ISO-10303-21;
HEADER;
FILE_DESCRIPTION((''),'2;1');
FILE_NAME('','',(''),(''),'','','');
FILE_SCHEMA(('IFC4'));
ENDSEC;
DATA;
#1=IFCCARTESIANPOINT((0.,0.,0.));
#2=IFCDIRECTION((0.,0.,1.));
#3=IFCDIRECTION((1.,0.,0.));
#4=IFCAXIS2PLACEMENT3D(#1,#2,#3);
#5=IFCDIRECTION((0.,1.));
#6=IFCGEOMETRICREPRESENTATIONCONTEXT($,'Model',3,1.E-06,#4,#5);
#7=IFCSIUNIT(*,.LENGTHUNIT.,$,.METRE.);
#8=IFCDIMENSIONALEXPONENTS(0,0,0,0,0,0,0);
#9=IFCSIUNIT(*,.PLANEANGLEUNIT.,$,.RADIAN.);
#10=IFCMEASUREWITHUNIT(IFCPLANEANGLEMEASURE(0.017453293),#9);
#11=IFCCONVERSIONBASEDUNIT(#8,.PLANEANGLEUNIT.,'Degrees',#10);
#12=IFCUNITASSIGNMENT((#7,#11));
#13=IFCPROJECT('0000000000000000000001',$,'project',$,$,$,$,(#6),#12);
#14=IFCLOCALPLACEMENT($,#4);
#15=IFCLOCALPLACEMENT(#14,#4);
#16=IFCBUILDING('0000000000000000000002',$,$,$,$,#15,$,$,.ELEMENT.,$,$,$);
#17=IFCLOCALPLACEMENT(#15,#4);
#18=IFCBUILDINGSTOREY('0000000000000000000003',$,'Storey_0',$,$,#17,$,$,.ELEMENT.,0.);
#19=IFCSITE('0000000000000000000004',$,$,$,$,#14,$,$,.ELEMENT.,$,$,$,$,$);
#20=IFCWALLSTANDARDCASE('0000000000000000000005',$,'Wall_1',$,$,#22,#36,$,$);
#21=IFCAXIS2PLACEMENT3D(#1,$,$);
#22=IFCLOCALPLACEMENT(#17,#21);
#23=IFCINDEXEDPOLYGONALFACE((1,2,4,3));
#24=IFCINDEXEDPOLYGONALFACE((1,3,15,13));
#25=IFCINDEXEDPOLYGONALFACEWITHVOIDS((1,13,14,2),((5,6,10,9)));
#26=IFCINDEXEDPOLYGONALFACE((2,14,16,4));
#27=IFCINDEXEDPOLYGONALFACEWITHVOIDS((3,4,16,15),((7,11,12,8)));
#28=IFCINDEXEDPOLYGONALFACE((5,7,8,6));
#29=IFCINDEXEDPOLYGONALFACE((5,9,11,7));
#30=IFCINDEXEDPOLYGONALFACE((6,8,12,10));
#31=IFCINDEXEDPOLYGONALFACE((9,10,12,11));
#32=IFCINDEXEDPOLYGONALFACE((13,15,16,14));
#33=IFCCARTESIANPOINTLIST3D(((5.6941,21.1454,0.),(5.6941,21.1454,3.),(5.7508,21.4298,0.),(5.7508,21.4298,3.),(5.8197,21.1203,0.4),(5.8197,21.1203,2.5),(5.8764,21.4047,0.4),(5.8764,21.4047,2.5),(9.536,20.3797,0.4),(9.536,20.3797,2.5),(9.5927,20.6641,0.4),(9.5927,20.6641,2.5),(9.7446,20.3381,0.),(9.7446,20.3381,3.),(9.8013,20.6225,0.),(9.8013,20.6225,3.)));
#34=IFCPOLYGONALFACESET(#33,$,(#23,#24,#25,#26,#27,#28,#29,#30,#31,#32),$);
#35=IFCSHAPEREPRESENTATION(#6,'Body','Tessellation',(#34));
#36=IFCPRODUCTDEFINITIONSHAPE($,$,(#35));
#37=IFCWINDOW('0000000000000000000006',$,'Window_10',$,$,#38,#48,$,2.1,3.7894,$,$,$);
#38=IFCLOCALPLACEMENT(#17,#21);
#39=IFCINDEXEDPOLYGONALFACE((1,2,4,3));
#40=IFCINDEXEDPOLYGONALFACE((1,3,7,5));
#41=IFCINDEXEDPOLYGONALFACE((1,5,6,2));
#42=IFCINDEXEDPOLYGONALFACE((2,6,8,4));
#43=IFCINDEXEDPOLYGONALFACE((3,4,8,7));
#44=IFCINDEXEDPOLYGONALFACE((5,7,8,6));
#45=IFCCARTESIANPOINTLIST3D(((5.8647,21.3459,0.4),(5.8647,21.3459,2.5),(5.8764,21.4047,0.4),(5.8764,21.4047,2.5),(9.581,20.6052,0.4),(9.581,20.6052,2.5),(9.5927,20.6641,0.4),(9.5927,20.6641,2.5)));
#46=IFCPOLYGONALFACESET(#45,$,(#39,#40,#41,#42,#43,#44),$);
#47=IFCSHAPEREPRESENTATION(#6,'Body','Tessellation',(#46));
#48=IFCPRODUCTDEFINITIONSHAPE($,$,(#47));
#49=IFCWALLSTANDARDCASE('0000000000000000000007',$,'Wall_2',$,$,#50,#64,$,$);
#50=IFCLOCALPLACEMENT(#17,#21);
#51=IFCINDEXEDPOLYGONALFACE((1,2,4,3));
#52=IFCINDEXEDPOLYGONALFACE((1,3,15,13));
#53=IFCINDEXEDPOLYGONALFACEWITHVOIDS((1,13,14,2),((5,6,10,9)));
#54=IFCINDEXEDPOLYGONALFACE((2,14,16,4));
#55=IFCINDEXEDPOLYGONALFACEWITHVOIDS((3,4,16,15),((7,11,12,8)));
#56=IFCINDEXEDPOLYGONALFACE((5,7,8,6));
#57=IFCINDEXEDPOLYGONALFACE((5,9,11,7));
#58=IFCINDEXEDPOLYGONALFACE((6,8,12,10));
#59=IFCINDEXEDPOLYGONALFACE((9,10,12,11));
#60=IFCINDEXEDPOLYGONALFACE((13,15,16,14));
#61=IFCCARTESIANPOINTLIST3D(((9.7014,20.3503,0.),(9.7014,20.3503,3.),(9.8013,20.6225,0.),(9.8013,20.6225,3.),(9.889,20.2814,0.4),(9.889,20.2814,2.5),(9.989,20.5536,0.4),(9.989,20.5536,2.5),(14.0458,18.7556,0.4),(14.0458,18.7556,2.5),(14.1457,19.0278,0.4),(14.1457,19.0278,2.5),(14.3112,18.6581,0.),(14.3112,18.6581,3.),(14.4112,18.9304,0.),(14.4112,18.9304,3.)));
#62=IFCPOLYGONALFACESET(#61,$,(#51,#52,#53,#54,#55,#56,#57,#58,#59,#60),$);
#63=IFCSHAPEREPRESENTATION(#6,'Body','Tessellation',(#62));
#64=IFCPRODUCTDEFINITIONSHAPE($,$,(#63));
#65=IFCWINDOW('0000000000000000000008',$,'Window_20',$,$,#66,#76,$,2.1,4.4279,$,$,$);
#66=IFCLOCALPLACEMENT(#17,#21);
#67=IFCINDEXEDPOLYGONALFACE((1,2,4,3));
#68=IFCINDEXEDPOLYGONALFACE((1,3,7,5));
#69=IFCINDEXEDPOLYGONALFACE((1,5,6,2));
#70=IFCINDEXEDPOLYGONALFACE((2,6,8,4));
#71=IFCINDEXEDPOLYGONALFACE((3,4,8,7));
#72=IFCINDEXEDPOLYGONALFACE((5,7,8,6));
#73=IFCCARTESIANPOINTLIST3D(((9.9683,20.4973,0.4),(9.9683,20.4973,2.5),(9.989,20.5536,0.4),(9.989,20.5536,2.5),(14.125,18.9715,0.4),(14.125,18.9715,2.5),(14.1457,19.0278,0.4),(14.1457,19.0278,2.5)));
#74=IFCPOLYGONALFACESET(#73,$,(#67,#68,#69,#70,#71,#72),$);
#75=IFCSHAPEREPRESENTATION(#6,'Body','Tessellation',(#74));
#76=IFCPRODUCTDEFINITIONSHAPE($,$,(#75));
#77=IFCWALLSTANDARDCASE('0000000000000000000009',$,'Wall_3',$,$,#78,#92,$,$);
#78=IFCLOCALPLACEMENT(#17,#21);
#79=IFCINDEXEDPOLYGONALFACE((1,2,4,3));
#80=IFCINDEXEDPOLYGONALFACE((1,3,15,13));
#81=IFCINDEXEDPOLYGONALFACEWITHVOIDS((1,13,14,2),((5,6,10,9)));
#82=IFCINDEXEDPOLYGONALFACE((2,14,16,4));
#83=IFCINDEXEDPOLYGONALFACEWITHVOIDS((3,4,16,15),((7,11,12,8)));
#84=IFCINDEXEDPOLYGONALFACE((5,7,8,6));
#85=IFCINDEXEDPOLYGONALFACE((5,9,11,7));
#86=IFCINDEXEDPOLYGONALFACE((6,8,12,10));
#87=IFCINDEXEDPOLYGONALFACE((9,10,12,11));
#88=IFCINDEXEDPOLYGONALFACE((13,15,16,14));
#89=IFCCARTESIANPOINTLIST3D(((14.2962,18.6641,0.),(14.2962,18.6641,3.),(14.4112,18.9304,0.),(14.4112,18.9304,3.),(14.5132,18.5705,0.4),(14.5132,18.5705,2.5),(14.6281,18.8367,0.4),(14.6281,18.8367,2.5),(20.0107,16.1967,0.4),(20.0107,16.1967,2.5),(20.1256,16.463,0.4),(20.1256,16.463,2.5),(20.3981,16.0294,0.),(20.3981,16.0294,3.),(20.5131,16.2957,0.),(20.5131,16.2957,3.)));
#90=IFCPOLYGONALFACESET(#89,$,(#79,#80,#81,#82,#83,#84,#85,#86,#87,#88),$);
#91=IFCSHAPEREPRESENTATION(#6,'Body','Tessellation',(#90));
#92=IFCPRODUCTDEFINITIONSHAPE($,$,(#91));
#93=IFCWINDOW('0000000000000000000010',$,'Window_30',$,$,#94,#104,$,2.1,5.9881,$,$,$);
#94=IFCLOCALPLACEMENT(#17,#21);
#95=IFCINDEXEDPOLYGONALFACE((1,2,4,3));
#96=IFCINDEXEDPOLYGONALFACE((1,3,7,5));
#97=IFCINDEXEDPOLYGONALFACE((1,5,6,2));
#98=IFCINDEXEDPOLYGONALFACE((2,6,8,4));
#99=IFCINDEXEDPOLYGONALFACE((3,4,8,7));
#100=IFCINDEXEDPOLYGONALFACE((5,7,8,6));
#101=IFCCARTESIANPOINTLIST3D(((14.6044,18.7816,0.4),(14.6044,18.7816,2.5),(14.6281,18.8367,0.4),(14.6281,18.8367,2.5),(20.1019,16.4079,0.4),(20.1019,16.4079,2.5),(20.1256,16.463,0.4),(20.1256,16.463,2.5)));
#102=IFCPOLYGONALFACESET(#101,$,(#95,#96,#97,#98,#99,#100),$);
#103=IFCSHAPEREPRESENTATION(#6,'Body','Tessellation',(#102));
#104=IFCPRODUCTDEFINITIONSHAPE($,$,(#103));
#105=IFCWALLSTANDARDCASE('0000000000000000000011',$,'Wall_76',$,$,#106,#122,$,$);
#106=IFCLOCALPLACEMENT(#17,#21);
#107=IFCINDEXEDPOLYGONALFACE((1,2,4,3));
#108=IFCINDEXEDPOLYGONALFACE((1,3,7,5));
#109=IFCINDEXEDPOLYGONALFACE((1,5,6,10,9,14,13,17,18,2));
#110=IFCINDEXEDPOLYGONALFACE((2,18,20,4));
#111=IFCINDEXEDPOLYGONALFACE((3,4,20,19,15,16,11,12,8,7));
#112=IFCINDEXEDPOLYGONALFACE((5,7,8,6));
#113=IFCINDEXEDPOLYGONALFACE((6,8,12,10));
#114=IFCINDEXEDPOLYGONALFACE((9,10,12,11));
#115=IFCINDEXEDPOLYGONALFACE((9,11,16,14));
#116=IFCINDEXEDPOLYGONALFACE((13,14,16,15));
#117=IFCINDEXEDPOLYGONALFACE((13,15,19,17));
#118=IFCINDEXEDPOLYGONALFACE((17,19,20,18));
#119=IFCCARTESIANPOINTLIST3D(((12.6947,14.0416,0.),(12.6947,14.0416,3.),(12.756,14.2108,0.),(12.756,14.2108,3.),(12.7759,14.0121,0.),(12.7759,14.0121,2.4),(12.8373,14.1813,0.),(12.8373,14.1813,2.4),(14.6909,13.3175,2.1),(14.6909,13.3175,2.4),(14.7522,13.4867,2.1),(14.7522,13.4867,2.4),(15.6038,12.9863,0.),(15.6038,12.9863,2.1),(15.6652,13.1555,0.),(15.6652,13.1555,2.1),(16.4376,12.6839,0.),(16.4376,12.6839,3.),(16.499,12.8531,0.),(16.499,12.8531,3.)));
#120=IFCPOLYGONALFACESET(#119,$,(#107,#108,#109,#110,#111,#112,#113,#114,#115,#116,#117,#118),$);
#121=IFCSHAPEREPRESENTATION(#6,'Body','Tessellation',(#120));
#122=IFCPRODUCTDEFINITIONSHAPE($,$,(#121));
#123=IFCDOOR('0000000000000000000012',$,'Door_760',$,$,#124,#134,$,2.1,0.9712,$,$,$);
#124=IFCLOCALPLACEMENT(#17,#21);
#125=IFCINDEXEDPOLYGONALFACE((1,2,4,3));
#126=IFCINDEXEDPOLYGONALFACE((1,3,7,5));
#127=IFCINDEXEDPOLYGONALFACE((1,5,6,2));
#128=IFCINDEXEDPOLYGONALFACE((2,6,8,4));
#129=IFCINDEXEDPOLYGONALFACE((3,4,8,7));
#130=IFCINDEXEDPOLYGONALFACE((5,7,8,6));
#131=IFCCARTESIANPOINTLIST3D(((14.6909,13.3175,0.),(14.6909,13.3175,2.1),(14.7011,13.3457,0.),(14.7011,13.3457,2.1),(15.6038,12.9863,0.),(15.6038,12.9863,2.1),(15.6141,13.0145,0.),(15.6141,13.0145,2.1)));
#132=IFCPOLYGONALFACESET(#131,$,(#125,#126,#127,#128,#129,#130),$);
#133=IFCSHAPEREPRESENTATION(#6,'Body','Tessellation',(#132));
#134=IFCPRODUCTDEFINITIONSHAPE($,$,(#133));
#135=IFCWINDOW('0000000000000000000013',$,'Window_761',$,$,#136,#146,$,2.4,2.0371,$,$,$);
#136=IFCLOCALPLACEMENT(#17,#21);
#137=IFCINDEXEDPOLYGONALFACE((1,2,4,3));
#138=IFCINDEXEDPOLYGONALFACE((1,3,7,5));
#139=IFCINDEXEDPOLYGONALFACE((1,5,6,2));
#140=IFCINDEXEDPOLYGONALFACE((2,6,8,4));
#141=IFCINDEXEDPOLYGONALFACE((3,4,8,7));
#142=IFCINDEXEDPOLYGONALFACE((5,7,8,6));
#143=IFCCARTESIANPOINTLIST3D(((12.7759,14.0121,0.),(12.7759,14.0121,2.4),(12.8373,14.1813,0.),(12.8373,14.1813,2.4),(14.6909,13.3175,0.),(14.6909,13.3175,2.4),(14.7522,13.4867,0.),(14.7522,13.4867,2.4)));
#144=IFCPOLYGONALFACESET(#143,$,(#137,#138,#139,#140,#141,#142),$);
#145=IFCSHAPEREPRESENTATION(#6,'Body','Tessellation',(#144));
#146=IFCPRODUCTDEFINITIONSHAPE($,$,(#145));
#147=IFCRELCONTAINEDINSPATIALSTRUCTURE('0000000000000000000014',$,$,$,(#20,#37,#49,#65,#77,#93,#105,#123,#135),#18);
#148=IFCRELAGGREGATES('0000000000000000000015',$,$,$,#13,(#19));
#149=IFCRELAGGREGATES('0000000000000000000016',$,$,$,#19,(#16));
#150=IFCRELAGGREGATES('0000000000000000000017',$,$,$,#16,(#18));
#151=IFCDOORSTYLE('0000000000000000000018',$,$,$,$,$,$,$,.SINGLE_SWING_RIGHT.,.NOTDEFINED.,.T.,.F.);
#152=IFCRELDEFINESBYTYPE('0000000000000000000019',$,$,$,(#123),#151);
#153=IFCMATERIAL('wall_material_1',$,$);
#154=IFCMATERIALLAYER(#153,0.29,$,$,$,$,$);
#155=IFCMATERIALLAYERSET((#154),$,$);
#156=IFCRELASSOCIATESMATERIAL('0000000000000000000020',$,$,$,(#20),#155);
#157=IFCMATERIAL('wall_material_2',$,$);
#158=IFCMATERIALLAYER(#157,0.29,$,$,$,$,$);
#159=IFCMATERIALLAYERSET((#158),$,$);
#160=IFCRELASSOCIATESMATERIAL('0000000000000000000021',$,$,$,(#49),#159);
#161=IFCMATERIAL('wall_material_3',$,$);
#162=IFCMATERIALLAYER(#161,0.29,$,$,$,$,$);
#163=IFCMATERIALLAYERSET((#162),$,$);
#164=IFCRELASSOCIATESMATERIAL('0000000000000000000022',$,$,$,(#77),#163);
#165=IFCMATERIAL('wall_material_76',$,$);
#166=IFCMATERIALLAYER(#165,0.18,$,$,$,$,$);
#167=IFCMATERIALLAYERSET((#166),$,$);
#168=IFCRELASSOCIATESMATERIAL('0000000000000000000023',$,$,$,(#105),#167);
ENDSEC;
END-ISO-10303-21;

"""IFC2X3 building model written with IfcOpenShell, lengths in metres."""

from ifc_helpers import new_model, entity, si_unit, converted_unit, direction, frame, frame_2d, origin_with_axes, place, context, project, spatial, polyline, rectangle, outline, extrude, material, layer, layer_set, layer_usage, type_object, element, fill, save


model = new_model("IFC2X3")

# Units and contexts
model_context = context("Model", 3, precision=1e-06, world=origin_with_axes(), true_north=direction((0.0, 1.0)))
ifc_project = project(units=[si_unit("LENGTHUNIT", "METRE"), converted_unit("PLANEANGLEUNIT", "Degrees", entity("IfcPlaneAngleMeasure", 0.017453293), si_unit("PLANEANGLEUNIT", "RADIAN"), dimensions=[0, 0, 0, 0, 0, 0, 0])], contexts=[model_context])

# Site, building, storey
site_placement = place(None, origin_with_axes())
site = spatial("IfcSite", under=ifc_project, at=site_placement, CompositionType="ELEMENT")
building_placement = place(site_placement, origin_with_axes())
building = spatial("IfcBuilding", under=site, at=building_placement, CompositionType="ELEMENT")
storey_placement = place(building_placement, origin_with_axes())
storey = spatial("IfcBuildingStorey", under=building, at=storey_placement, Name="Storey_0", CompositionType="ELEMENT", Elevation=0.0)

# Walls, openings, windows
ifc_material_1 = material(Name="wall_material_1")
ifc_layer_1 = layer(ifc_material_1, 0.29)
ifc_layer_set_1 = layer_set([ifc_layer_1])
ifc_layer_usage_1 = layer_usage(ifc_layer_set_1, "AXIS2", "NEGATIVE", 0.0)
wall_1_placement = place(storey_placement, frame((5.7508, 21.4298, 0.0), z_axis=(0.0, 0.0, 1.0), x_axis=(0.980712, -0.195456, 0.0)))
wall_1 = element("IfcWallStandardCase", 1, at=wall_1_placement, inside=storey, material=ifc_layer_usage_1, Name="Wall_1", context=model_context, shape_type="SweptSolid", body=[
    extrude(outline(polyline([(0.0, 0.0), (4.1302, 0.0), (4.1302, -0.29), (0.0, -0.29), (0.0, 0.0)])), origin_with_axes(), (0.0, 0.0, 1.0), 3.0),
])
opening_1_placement = place(wall_1_placement, frame((0.1281, 0.0, 0.4), z_axis=(0.0, 0.0, 1.0), x_axis=(1.0, 0.0, 0.0)))
opening_1 = element("IfcOpeningElement", 2, at=opening_1_placement, cuts=wall_1, context=model_context, shape_type="SweptSolid", body=[
    extrude(rectangle(XDim=3.7894, YDim=2.1, at=frame_2d((1.05, -1.8947), x_axis=(0.0, 1.0))), frame((0.0, 0.01, 0.0), z_axis=(0.0, -1.0, 0.0), x_axis=(0.0, 0.0, 1.0)), (0.0, 0.0, 1.0), 0.31),
])
window_1_placement = place(storey_placement, frame((0.0, 0.0, 0.4), z_axis=(0.0, 0.0, 1.0), x_axis=(1.0, 0.0, 0.0)))
window_1 = element("IfcWindow", 3, at=window_1_placement, inside=storey, Name="Window_10", OverallHeight=2.1, OverallWidth=3.7894, context=model_context, shape_type="SweptSolid", body=[
    extrude(outline(polyline([(5.8764, 21.4047), (9.5927, 20.6641), (9.581, 20.6052), (5.8647, 21.3459), (5.8764, 21.4047)])), origin_with_axes(), (0.0, 0.0, 1.0), 2.1),
])
fill(opening_1, window_1)
ifc_material_2 = material(Name="wall_material_2")
ifc_layer_2 = layer(ifc_material_2, 0.29)
ifc_layer_set_2 = layer_set([ifc_layer_2])
ifc_layer_usage_2 = layer_usage(ifc_layer_set_2, "AXIS2", "NEGATIVE", 0.0)
wall_2_placement = place(storey_placement, frame((9.8013, 20.6225, 0.0), z_axis=(0.0, 0.0, 1.0), x_axis=(0.938754, -0.344588, 0.0)))
wall_2 = element("IfcWallStandardCase", 4, at=wall_2_placement, inside=storey, material=ifc_layer_usage_2, Name="Wall_2", context=model_context, shape_type="SweptSolid", body=[
    extrude(outline(polyline([(0.0, 0.0), (4.9106, 0.0), (4.9106, -0.29), (0.0, -0.29), (0.0, 0.0)])), origin_with_axes(), (0.0, 0.0, 1.0), 3.0),
])
opening_2_placement = place(wall_2_placement, frame((0.1999, 0.0, 0.4), z_axis=(0.0, 0.0, 1.0), x_axis=(1.0, 0.0, 0.0)))
opening_2 = element("IfcOpeningElement", 5, at=opening_2_placement, cuts=wall_2, context=model_context, shape_type="SweptSolid", body=[
    extrude(rectangle(XDim=4.4279, YDim=2.1, at=frame_2d((1.05, -2.214), x_axis=(0.0, 1.0))), frame((0.0, 0.01, 0.0), z_axis=(0.0, -1.0, 0.0), x_axis=(0.0, 0.0, 1.0)), (0.0, 0.0, 1.0), 0.31),
])
window_2_placement = place(storey_placement, frame((0.0, 0.0, 0.4), z_axis=(0.0, 0.0, 1.0), x_axis=(1.0, 0.0, 0.0)))
window_2 = element("IfcWindow", 6, at=window_2_placement, inside=storey, Name="Window_20", OverallHeight=2.1, OverallWidth=4.4279, context=model_context, shape_type="SweptSolid", body=[
    extrude(outline(polyline([(9.989, 20.5536), (14.1457, 19.0278), (14.125, 18.9715), (9.9683, 20.4973), (9.989, 20.5536)])), origin_with_axes(), (0.0, 0.0, 1.0), 2.1),
])
fill(opening_2, window_2)
ifc_material_3 = material(Name="wall_material_3")
ifc_layer_3 = layer(ifc_material_3, 0.29)
ifc_layer_set_3 = layer_set([ifc_layer_3])
ifc_layer_usage_3 = layer_usage(ifc_layer_set_3, "AXIS2", "NEGATIVE", 0.0)
wall_3_placement = place(storey_placement, frame((14.4112, 18.9304, 0.0), z_axis=(0.0, 0.0, 1.0), x_axis=(0.918074, -0.39641, 0.0)))
wall_3 = element("IfcWallStandardCase", 7, at=wall_3_placement, inside=storey, material=ifc_layer_usage_3, Name="Wall_3", context=model_context, shape_type="SweptSolid", body=[
    extrude(outline(polyline([(0.0, 0.0), (6.6464, 0.0), (6.6464, -0.29), (0.0, -0.29), (0.0, 0.0)])), origin_with_axes(), (0.0, 0.0, 1.0), 3.0),
])
opening_3_placement = place(wall_3_placement, frame((0.2363, 0.0, 0.4), z_axis=(0.0, 0.0, 1.0), x_axis=(1.0, 0.0, 0.0)))
opening_3 = element("IfcOpeningElement", 8, at=opening_3_placement, cuts=wall_3, context=model_context, shape_type="SweptSolid", body=[
    extrude(rectangle(XDim=5.9881, YDim=2.1, at=frame_2d((1.05, -2.994), x_axis=(0.0, 1.0))), frame((0.0, 0.01, 0.0), z_axis=(0.0, -1.0, 0.0), x_axis=(0.0, 0.0, 1.0)), (0.0, 0.0, 1.0), 0.31),
])
window_3_placement = place(storey_placement, frame((0.0, 0.0, 0.4), z_axis=(0.0, 0.0, 1.0), x_axis=(1.0, 0.0, 0.0)))
window_3 = element("IfcWindow", 9, at=window_3_placement, inside=storey, Name="Window_30", OverallHeight=2.1, OverallWidth=5.9881, context=model_context, shape_type="SweptSolid", body=[
    extrude(outline(polyline([(14.6281, 18.8367), (20.1256, 16.463), (20.1019, 16.4079), (14.6044, 18.7816), (14.6281, 18.8367)])), origin_with_axes(), (0.0, 0.0, 1.0), 2.1),
])
fill(opening_3, window_3)

# Wall, openings, door, window
ifc_material_4 = material(Name="wall_material_76")
ifc_layer_4 = layer(ifc_material_4, 0.18)
ifc_layer_set_4 = layer_set([ifc_layer_4])
ifc_layer_usage_4 = layer_usage(ifc_layer_set_4, "AXIS2", "POSITIVE", 0.0)
wall_4_placement = place(storey_placement, frame((16.499, 12.8531, 0.0), z_axis=(0.0, 0.0, 1.0), x_axis=(-0.940064, 0.340998, 0.0)))
wall_4 = element("IfcWallStandardCase", 10, at=wall_4_placement, inside=storey, material=ifc_layer_usage_4, Name="Wall_76", context=model_context, shape_type="SweptSolid", body=[
    extrude(outline(polyline([(0.0, 0.18), (3.9816, 0.18), (3.9816, 0.0), (0.0, 0.0), (0.0, 0.18)])), origin_with_axes(), (0.0, 0.0, 1.0), 3.0),
])
opening_4_placement = place(wall_4_placement, frame((0.8869, 0.18, 0.0), z_axis=(0.0, 0.0, 1.0), x_axis=(1.0, 0.0, 0.0)))
opening_4 = element("IfcOpeningElement", 11, at=opening_4_placement, cuts=wall_4, context=model_context, shape_type="SweptSolid", body=[
    extrude(rectangle(XDim=0.9712, YDim=2.1, at=frame_2d((1.05, -0.4856), x_axis=(0.0, 1.0))), frame((0.0, 0.01, 0.0), z_axis=(0.0, -1.0, 0.0), x_axis=(0.0, 0.0, 1.0)), (0.0, 0.0, 1.0), 0.2),
])
opening_5_placement = place(wall_4_placement, frame((1.8581, 0.18, 0.0), z_axis=(0.0, 0.0, 1.0), x_axis=(1.0, 0.0, 0.0)))
opening_5 = element("IfcOpeningElement", 12, at=opening_5_placement, cuts=wall_4, context=model_context, shape_type="SweptSolid", body=[
    extrude(rectangle(XDim=2.0371, YDim=2.4, at=frame_2d((1.2, -1.0185), x_axis=(0.0, 1.0))), frame((0.0, 0.01, 0.0), z_axis=(0.0, -1.0, 0.0), x_axis=(0.0, 0.0, 1.0)), (0.0, 0.0, 1.0), 0.2),
])
door_style_1 = type_object("IfcDoorStyle", ConstructionType="NOTDEFINED", OperationType="SINGLE_SWING_RIGHT", ParameterTakesPrecedence=True, Sizeable=False)
door_1_placement = place(storey_placement, origin_with_axes())
door_1 = element("IfcDoor", 13, at=door_1_placement, inside=storey, type_object=door_style_1, Name="Door_760", OverallHeight=2.1, OverallWidth=0.9712, context=model_context, shape_type="SweptSolid", body=[
    extrude(outline(polyline([(15.6038, 12.9863), (14.6909, 13.3175), (14.7011, 13.3457), (15.6141, 13.0145), (15.6038, 12.9863)])), origin_with_axes(), (0.0, 0.0, 1.0), 2.1),
])
fill(opening_4, door_1)
window_4_placement = place(storey_placement, origin_with_axes())
window_4 = element("IfcWindow", 14, at=window_4_placement, inside=storey, Name="Window_761", OverallHeight=2.4, OverallWidth=2.0371, context=model_context, shape_type="SweptSolid", body=[
    extrude(outline(polyline([(14.6909, 13.3175), (12.7759, 14.0121), (12.8373, 14.1813), (14.7522, 13.4867), (14.6909, 13.3175)])), origin_with_axes(), (0.0, 0.0, 1.0), 2.4),
])
fill(opening_5, window_4)

save(model, "model.ifc")
